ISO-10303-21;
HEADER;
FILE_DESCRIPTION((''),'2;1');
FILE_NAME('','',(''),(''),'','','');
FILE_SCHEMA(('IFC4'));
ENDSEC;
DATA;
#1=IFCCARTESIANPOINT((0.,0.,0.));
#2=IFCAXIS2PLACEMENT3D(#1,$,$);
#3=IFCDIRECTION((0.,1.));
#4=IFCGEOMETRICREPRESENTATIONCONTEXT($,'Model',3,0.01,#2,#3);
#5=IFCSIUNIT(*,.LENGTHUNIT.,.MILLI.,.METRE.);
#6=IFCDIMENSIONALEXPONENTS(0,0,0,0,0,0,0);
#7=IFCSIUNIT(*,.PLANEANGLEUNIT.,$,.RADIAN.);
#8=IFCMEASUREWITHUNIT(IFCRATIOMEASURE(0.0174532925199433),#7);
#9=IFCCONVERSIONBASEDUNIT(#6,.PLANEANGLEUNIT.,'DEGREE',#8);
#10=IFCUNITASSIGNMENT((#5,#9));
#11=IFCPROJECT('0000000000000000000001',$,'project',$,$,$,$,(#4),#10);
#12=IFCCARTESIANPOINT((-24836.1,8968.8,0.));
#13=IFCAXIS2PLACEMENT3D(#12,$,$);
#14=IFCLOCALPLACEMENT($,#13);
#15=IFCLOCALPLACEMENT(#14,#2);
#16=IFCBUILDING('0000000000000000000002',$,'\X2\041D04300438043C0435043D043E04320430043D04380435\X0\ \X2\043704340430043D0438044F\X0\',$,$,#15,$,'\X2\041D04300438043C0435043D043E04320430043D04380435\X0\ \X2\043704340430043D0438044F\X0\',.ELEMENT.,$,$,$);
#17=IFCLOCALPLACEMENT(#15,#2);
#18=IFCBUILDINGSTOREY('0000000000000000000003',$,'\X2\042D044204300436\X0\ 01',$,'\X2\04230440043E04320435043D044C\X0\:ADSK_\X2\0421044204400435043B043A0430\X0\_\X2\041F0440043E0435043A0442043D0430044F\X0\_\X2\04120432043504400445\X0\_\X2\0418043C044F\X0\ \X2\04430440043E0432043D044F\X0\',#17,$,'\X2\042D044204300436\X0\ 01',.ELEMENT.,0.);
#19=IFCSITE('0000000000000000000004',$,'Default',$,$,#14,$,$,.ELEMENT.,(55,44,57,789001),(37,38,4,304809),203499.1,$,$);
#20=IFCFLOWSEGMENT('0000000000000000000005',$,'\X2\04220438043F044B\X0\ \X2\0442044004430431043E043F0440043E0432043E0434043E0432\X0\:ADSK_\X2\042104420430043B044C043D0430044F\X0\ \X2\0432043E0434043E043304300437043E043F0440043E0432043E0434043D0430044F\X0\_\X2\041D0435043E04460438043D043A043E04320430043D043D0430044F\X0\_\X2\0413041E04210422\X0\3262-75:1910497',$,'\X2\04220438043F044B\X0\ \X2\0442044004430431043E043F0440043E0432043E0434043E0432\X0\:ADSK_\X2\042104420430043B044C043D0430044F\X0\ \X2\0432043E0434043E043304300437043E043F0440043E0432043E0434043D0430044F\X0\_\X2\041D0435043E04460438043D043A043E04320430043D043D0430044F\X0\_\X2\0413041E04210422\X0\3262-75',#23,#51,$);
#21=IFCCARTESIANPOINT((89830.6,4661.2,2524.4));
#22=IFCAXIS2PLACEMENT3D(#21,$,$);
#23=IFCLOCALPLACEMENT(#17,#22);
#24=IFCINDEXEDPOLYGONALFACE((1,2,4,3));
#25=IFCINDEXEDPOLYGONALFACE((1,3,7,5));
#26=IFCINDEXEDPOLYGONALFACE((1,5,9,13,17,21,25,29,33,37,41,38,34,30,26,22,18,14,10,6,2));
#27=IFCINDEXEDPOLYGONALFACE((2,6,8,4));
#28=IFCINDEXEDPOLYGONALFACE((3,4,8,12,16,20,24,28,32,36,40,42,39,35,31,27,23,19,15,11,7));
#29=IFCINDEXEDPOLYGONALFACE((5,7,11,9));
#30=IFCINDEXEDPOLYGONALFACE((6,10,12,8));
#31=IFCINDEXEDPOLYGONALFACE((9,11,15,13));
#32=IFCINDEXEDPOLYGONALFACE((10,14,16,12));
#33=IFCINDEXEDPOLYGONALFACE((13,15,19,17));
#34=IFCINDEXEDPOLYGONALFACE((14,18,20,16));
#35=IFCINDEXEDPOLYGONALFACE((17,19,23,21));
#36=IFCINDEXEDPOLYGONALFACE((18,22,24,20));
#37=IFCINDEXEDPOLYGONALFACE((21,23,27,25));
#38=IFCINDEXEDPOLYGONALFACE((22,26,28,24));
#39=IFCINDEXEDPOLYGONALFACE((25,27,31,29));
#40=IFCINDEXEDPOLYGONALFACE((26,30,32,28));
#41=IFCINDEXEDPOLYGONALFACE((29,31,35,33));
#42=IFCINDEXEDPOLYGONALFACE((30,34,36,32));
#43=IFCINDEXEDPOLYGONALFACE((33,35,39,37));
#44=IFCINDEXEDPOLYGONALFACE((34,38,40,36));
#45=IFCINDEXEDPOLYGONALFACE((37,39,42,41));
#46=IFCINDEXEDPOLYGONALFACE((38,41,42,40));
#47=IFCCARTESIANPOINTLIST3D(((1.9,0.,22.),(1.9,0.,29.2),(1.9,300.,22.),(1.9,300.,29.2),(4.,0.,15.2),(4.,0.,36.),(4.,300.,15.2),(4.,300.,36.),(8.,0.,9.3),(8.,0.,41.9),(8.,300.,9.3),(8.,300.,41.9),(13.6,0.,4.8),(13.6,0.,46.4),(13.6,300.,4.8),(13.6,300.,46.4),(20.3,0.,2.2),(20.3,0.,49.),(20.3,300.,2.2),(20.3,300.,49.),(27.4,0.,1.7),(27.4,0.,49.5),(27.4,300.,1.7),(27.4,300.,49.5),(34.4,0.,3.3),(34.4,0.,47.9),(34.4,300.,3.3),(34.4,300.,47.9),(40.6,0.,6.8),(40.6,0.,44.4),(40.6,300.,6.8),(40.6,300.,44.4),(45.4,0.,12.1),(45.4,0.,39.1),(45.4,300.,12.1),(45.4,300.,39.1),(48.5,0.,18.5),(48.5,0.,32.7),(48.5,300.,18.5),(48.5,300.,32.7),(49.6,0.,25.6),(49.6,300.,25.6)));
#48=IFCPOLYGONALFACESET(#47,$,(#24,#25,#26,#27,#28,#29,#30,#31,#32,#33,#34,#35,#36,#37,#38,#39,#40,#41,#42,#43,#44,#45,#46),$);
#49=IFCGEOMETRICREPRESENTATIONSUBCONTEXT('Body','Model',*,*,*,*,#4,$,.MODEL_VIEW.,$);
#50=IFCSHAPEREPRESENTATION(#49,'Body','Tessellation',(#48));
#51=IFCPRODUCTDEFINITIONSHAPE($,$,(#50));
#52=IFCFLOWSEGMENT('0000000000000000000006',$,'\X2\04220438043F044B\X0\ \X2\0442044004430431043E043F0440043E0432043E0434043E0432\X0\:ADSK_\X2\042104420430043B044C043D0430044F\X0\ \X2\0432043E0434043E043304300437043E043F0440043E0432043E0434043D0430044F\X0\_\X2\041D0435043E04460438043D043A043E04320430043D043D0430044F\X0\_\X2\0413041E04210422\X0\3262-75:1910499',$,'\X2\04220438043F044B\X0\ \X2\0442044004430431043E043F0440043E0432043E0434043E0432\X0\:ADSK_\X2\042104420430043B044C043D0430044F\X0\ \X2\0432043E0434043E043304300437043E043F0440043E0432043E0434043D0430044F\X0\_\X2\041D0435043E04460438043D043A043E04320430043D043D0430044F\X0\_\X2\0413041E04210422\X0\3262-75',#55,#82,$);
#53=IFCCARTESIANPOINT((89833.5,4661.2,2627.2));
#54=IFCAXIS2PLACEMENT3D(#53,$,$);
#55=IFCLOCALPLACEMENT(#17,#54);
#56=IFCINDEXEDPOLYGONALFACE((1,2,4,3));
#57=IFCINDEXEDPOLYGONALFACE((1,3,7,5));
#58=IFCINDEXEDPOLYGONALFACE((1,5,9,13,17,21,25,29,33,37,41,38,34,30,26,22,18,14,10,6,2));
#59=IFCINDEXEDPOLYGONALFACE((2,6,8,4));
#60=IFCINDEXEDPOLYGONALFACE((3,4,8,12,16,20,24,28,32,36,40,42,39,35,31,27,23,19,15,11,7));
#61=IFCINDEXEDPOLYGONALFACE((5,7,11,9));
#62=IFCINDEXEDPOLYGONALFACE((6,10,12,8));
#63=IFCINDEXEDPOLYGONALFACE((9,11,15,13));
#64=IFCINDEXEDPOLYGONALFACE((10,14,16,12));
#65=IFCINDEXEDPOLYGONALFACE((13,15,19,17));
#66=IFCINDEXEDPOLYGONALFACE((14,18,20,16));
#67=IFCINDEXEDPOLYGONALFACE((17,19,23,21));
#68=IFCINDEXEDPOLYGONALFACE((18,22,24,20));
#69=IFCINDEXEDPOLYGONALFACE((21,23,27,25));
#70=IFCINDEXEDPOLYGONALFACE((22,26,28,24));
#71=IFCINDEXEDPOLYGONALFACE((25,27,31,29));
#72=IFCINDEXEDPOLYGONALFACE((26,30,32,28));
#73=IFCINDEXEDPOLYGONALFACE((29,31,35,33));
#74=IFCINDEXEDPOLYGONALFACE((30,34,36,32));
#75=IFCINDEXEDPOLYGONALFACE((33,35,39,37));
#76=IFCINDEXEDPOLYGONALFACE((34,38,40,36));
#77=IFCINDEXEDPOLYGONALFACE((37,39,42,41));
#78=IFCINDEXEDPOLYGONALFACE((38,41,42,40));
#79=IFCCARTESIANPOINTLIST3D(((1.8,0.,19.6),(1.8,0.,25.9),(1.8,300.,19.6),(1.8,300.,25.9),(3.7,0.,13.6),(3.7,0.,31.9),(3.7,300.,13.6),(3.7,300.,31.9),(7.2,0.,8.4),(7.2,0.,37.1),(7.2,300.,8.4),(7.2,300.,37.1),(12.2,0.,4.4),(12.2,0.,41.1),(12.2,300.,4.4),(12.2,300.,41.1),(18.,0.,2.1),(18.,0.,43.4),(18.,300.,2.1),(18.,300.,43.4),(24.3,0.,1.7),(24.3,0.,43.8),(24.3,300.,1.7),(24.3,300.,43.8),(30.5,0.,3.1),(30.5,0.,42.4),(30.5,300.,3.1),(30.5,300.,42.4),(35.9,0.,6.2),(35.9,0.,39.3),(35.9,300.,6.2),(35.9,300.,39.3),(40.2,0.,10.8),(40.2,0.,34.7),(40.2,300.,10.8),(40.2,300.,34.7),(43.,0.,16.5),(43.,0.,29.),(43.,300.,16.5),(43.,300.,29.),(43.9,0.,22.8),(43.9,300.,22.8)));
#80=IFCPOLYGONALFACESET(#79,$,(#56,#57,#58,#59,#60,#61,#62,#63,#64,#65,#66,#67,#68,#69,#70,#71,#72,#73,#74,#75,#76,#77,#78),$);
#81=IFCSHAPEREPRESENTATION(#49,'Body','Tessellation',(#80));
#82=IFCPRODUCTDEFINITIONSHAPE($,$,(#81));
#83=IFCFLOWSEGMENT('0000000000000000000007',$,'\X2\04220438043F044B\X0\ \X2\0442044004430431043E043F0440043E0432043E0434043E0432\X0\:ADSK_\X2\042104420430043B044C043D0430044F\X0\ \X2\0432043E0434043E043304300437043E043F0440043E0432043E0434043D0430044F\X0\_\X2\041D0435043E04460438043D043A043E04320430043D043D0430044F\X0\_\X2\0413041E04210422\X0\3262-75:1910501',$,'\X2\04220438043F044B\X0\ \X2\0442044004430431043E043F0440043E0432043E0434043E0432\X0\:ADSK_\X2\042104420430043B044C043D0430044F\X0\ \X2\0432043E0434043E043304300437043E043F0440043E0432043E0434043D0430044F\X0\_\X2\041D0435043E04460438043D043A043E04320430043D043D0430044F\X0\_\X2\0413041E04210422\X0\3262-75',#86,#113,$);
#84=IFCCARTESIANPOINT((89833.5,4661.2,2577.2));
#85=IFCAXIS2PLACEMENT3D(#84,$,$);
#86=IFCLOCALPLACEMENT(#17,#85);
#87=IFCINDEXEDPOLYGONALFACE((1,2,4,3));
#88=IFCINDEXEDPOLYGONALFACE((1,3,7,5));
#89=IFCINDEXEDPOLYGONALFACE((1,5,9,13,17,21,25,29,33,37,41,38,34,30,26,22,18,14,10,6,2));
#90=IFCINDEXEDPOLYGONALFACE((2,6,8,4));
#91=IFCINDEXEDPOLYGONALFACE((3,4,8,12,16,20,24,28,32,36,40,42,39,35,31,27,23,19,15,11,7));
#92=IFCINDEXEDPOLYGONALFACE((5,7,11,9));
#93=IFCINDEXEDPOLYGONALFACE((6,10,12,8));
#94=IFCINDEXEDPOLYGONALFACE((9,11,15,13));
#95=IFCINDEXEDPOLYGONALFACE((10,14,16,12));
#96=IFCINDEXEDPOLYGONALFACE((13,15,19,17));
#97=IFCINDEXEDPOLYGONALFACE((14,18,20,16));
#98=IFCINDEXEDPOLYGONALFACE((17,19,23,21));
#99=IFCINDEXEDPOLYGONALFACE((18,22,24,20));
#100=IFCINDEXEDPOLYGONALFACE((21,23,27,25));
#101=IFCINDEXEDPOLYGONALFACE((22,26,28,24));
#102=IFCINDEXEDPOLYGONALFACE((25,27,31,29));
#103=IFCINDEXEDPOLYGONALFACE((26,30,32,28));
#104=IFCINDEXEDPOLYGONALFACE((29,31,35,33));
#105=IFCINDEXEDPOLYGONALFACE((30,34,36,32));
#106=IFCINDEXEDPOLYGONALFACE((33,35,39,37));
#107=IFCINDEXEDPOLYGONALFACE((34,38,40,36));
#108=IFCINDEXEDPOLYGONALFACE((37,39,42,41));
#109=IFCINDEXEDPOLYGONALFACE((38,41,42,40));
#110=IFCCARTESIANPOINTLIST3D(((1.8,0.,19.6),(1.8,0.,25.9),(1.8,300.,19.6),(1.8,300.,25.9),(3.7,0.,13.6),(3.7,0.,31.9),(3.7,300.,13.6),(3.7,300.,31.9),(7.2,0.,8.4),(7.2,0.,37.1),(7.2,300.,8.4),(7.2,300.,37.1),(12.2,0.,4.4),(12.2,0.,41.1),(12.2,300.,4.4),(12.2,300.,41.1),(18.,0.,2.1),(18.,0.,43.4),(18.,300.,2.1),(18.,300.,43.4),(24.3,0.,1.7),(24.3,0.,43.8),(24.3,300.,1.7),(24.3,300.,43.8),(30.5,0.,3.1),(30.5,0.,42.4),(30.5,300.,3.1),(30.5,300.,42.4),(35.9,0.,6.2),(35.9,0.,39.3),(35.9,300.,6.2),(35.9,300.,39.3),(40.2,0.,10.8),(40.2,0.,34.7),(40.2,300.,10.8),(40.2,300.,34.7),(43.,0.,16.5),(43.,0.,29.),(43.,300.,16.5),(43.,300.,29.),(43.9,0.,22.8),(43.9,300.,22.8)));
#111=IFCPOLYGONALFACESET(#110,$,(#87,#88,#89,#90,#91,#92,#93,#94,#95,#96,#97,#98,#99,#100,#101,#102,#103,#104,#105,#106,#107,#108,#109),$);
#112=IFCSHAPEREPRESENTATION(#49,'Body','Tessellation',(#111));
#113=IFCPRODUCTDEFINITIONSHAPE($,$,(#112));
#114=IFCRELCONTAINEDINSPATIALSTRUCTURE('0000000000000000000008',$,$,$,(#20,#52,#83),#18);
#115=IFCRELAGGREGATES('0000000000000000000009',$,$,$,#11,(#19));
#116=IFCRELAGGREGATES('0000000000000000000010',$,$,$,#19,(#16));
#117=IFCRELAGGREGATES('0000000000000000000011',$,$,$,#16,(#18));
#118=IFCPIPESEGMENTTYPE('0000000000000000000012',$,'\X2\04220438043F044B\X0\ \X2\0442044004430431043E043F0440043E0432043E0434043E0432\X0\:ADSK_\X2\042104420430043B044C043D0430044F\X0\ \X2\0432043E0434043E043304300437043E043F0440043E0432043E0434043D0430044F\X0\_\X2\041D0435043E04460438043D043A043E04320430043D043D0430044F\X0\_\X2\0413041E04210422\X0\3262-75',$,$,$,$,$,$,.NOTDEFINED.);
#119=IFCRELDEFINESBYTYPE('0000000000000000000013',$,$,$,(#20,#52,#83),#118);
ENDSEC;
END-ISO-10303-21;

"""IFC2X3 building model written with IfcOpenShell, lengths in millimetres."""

from ifc_helpers import new_model, entity, si_unit, converted_unit, direction, frame, origin, origin_2d_with_axis, place, context, subcontext, project, spatial, circle, extrude, type_object, element, save


model = new_model("IFC2X3")

# Units and contexts
model_context = context("Model", 3, precision=0.01, world=origin(), true_north=direction((0.0, 1.0)))
body_context = subcontext(model_context, "Body", "Model", "MODEL_VIEW")
ifc_project = project(units=[si_unit("LENGTHUNIT", "METRE", prefix="MILLI"), converted_unit("PLANEANGLEUNIT", "DEGREE", entity("IfcRatioMeasure", 0.0174532925199433), si_unit("PLANEANGLEUNIT", "RADIAN"), dimensions=[0, 0, 0, 0, 0, 0, 0])], contexts=[model_context])

# Site, building, storey
site_placement = place(None, frame((-24836.1, 8968.8, 0.0)))
site = spatial("IfcSite", under=ifc_project, at=site_placement, Name="Default", CompositionType="ELEMENT", RefLatitude=(55, 44, 57, 789001), RefLongitude=(37, 38, 4, 304809), RefElevation=203499.1)
building_placement = place(site_placement, origin())
building = spatial("IfcBuilding", under=site, at=building_placement, Name="Наименование здания", LongName="Наименование здания", CompositionType="ELEMENT")
storey_placement = place(building_placement, origin())
storey = spatial("IfcBuildingStorey", under=building, at=storey_placement, Name="Этаж 01", ObjectType="Уровень:ADSK_Стрелка_Проектная_Вверх_Имя уровня", LongName="Этаж 01", CompositionType="ELEMENT", Elevation=0.0)

# Flow segments
pipe_segment_type_1 = type_object("IfcPipeSegmentType", Name="Типы трубопроводов:ADSK_Стальная водогазопроводная_Неоцинкованная_ГОСТ3262-75", PredefinedType="NOTDEFINED")
flow_segment_1_placement = place(storey_placement, frame((89830.6, 4661.2, 2524.4)))
element("IfcFlowSegment", 1, at=flow_segment_1_placement, inside=storey, type_object=pipe_segment_type_1, Name="Типы трубопроводов:ADSK_Стальная водогазопроводная_Неоцинкованная_ГОСТ3262-75:1910497", ObjectType="Типы трубопроводов:ADSK_Стальная водогазопроводная_Неоцинкованная_ГОСТ3262-75", context=body_context, shape_type="SweptSolid", body=[
    extrude(circle(Radius=24.0, at=origin_2d_with_axis()), frame((25.6, 0.0, 25.6), z_axis=(0.0, 1.0, 0.0), x_axis=(1.0, 0.0, 0.0)), (0.0, 0.0, 1.0), 300.0),
])
for number, where, name in (
    (2, (89833.5, 4661.2, 2627.2), "Типы трубопроводов:ADSK_Стальная водогазопроводная_Неоцинкованная_ГОСТ3262-75:1910499"),
    (3, (89833.5, 4661.2, 2577.2), "Типы трубопроводов:ADSK_Стальная водогазопроводная_Неоцинкованная_ГОСТ3262-75:1910501"),
):
    element("IfcFlowSegment", number, at=place(storey_placement, frame(where)), inside=storey, type_object=pipe_segment_type_1, Name=name, ObjectType="Типы трубопроводов:ADSK_Стальная водогазопроводная_Неоцинкованная_ГОСТ3262-75", context=body_context, shape_type="SweptSolid", body=[
        extrude(circle(Radius=21.1, at=origin_2d_with_axis()), frame((22.8, 0.0, 22.8), z_axis=(0.0, 1.0, 0.0), x_axis=(1.0, 0.0, 0.0)), (0.0, 0.0, 1.0), 300.0),
    ])

save(model, "model.ifc")
